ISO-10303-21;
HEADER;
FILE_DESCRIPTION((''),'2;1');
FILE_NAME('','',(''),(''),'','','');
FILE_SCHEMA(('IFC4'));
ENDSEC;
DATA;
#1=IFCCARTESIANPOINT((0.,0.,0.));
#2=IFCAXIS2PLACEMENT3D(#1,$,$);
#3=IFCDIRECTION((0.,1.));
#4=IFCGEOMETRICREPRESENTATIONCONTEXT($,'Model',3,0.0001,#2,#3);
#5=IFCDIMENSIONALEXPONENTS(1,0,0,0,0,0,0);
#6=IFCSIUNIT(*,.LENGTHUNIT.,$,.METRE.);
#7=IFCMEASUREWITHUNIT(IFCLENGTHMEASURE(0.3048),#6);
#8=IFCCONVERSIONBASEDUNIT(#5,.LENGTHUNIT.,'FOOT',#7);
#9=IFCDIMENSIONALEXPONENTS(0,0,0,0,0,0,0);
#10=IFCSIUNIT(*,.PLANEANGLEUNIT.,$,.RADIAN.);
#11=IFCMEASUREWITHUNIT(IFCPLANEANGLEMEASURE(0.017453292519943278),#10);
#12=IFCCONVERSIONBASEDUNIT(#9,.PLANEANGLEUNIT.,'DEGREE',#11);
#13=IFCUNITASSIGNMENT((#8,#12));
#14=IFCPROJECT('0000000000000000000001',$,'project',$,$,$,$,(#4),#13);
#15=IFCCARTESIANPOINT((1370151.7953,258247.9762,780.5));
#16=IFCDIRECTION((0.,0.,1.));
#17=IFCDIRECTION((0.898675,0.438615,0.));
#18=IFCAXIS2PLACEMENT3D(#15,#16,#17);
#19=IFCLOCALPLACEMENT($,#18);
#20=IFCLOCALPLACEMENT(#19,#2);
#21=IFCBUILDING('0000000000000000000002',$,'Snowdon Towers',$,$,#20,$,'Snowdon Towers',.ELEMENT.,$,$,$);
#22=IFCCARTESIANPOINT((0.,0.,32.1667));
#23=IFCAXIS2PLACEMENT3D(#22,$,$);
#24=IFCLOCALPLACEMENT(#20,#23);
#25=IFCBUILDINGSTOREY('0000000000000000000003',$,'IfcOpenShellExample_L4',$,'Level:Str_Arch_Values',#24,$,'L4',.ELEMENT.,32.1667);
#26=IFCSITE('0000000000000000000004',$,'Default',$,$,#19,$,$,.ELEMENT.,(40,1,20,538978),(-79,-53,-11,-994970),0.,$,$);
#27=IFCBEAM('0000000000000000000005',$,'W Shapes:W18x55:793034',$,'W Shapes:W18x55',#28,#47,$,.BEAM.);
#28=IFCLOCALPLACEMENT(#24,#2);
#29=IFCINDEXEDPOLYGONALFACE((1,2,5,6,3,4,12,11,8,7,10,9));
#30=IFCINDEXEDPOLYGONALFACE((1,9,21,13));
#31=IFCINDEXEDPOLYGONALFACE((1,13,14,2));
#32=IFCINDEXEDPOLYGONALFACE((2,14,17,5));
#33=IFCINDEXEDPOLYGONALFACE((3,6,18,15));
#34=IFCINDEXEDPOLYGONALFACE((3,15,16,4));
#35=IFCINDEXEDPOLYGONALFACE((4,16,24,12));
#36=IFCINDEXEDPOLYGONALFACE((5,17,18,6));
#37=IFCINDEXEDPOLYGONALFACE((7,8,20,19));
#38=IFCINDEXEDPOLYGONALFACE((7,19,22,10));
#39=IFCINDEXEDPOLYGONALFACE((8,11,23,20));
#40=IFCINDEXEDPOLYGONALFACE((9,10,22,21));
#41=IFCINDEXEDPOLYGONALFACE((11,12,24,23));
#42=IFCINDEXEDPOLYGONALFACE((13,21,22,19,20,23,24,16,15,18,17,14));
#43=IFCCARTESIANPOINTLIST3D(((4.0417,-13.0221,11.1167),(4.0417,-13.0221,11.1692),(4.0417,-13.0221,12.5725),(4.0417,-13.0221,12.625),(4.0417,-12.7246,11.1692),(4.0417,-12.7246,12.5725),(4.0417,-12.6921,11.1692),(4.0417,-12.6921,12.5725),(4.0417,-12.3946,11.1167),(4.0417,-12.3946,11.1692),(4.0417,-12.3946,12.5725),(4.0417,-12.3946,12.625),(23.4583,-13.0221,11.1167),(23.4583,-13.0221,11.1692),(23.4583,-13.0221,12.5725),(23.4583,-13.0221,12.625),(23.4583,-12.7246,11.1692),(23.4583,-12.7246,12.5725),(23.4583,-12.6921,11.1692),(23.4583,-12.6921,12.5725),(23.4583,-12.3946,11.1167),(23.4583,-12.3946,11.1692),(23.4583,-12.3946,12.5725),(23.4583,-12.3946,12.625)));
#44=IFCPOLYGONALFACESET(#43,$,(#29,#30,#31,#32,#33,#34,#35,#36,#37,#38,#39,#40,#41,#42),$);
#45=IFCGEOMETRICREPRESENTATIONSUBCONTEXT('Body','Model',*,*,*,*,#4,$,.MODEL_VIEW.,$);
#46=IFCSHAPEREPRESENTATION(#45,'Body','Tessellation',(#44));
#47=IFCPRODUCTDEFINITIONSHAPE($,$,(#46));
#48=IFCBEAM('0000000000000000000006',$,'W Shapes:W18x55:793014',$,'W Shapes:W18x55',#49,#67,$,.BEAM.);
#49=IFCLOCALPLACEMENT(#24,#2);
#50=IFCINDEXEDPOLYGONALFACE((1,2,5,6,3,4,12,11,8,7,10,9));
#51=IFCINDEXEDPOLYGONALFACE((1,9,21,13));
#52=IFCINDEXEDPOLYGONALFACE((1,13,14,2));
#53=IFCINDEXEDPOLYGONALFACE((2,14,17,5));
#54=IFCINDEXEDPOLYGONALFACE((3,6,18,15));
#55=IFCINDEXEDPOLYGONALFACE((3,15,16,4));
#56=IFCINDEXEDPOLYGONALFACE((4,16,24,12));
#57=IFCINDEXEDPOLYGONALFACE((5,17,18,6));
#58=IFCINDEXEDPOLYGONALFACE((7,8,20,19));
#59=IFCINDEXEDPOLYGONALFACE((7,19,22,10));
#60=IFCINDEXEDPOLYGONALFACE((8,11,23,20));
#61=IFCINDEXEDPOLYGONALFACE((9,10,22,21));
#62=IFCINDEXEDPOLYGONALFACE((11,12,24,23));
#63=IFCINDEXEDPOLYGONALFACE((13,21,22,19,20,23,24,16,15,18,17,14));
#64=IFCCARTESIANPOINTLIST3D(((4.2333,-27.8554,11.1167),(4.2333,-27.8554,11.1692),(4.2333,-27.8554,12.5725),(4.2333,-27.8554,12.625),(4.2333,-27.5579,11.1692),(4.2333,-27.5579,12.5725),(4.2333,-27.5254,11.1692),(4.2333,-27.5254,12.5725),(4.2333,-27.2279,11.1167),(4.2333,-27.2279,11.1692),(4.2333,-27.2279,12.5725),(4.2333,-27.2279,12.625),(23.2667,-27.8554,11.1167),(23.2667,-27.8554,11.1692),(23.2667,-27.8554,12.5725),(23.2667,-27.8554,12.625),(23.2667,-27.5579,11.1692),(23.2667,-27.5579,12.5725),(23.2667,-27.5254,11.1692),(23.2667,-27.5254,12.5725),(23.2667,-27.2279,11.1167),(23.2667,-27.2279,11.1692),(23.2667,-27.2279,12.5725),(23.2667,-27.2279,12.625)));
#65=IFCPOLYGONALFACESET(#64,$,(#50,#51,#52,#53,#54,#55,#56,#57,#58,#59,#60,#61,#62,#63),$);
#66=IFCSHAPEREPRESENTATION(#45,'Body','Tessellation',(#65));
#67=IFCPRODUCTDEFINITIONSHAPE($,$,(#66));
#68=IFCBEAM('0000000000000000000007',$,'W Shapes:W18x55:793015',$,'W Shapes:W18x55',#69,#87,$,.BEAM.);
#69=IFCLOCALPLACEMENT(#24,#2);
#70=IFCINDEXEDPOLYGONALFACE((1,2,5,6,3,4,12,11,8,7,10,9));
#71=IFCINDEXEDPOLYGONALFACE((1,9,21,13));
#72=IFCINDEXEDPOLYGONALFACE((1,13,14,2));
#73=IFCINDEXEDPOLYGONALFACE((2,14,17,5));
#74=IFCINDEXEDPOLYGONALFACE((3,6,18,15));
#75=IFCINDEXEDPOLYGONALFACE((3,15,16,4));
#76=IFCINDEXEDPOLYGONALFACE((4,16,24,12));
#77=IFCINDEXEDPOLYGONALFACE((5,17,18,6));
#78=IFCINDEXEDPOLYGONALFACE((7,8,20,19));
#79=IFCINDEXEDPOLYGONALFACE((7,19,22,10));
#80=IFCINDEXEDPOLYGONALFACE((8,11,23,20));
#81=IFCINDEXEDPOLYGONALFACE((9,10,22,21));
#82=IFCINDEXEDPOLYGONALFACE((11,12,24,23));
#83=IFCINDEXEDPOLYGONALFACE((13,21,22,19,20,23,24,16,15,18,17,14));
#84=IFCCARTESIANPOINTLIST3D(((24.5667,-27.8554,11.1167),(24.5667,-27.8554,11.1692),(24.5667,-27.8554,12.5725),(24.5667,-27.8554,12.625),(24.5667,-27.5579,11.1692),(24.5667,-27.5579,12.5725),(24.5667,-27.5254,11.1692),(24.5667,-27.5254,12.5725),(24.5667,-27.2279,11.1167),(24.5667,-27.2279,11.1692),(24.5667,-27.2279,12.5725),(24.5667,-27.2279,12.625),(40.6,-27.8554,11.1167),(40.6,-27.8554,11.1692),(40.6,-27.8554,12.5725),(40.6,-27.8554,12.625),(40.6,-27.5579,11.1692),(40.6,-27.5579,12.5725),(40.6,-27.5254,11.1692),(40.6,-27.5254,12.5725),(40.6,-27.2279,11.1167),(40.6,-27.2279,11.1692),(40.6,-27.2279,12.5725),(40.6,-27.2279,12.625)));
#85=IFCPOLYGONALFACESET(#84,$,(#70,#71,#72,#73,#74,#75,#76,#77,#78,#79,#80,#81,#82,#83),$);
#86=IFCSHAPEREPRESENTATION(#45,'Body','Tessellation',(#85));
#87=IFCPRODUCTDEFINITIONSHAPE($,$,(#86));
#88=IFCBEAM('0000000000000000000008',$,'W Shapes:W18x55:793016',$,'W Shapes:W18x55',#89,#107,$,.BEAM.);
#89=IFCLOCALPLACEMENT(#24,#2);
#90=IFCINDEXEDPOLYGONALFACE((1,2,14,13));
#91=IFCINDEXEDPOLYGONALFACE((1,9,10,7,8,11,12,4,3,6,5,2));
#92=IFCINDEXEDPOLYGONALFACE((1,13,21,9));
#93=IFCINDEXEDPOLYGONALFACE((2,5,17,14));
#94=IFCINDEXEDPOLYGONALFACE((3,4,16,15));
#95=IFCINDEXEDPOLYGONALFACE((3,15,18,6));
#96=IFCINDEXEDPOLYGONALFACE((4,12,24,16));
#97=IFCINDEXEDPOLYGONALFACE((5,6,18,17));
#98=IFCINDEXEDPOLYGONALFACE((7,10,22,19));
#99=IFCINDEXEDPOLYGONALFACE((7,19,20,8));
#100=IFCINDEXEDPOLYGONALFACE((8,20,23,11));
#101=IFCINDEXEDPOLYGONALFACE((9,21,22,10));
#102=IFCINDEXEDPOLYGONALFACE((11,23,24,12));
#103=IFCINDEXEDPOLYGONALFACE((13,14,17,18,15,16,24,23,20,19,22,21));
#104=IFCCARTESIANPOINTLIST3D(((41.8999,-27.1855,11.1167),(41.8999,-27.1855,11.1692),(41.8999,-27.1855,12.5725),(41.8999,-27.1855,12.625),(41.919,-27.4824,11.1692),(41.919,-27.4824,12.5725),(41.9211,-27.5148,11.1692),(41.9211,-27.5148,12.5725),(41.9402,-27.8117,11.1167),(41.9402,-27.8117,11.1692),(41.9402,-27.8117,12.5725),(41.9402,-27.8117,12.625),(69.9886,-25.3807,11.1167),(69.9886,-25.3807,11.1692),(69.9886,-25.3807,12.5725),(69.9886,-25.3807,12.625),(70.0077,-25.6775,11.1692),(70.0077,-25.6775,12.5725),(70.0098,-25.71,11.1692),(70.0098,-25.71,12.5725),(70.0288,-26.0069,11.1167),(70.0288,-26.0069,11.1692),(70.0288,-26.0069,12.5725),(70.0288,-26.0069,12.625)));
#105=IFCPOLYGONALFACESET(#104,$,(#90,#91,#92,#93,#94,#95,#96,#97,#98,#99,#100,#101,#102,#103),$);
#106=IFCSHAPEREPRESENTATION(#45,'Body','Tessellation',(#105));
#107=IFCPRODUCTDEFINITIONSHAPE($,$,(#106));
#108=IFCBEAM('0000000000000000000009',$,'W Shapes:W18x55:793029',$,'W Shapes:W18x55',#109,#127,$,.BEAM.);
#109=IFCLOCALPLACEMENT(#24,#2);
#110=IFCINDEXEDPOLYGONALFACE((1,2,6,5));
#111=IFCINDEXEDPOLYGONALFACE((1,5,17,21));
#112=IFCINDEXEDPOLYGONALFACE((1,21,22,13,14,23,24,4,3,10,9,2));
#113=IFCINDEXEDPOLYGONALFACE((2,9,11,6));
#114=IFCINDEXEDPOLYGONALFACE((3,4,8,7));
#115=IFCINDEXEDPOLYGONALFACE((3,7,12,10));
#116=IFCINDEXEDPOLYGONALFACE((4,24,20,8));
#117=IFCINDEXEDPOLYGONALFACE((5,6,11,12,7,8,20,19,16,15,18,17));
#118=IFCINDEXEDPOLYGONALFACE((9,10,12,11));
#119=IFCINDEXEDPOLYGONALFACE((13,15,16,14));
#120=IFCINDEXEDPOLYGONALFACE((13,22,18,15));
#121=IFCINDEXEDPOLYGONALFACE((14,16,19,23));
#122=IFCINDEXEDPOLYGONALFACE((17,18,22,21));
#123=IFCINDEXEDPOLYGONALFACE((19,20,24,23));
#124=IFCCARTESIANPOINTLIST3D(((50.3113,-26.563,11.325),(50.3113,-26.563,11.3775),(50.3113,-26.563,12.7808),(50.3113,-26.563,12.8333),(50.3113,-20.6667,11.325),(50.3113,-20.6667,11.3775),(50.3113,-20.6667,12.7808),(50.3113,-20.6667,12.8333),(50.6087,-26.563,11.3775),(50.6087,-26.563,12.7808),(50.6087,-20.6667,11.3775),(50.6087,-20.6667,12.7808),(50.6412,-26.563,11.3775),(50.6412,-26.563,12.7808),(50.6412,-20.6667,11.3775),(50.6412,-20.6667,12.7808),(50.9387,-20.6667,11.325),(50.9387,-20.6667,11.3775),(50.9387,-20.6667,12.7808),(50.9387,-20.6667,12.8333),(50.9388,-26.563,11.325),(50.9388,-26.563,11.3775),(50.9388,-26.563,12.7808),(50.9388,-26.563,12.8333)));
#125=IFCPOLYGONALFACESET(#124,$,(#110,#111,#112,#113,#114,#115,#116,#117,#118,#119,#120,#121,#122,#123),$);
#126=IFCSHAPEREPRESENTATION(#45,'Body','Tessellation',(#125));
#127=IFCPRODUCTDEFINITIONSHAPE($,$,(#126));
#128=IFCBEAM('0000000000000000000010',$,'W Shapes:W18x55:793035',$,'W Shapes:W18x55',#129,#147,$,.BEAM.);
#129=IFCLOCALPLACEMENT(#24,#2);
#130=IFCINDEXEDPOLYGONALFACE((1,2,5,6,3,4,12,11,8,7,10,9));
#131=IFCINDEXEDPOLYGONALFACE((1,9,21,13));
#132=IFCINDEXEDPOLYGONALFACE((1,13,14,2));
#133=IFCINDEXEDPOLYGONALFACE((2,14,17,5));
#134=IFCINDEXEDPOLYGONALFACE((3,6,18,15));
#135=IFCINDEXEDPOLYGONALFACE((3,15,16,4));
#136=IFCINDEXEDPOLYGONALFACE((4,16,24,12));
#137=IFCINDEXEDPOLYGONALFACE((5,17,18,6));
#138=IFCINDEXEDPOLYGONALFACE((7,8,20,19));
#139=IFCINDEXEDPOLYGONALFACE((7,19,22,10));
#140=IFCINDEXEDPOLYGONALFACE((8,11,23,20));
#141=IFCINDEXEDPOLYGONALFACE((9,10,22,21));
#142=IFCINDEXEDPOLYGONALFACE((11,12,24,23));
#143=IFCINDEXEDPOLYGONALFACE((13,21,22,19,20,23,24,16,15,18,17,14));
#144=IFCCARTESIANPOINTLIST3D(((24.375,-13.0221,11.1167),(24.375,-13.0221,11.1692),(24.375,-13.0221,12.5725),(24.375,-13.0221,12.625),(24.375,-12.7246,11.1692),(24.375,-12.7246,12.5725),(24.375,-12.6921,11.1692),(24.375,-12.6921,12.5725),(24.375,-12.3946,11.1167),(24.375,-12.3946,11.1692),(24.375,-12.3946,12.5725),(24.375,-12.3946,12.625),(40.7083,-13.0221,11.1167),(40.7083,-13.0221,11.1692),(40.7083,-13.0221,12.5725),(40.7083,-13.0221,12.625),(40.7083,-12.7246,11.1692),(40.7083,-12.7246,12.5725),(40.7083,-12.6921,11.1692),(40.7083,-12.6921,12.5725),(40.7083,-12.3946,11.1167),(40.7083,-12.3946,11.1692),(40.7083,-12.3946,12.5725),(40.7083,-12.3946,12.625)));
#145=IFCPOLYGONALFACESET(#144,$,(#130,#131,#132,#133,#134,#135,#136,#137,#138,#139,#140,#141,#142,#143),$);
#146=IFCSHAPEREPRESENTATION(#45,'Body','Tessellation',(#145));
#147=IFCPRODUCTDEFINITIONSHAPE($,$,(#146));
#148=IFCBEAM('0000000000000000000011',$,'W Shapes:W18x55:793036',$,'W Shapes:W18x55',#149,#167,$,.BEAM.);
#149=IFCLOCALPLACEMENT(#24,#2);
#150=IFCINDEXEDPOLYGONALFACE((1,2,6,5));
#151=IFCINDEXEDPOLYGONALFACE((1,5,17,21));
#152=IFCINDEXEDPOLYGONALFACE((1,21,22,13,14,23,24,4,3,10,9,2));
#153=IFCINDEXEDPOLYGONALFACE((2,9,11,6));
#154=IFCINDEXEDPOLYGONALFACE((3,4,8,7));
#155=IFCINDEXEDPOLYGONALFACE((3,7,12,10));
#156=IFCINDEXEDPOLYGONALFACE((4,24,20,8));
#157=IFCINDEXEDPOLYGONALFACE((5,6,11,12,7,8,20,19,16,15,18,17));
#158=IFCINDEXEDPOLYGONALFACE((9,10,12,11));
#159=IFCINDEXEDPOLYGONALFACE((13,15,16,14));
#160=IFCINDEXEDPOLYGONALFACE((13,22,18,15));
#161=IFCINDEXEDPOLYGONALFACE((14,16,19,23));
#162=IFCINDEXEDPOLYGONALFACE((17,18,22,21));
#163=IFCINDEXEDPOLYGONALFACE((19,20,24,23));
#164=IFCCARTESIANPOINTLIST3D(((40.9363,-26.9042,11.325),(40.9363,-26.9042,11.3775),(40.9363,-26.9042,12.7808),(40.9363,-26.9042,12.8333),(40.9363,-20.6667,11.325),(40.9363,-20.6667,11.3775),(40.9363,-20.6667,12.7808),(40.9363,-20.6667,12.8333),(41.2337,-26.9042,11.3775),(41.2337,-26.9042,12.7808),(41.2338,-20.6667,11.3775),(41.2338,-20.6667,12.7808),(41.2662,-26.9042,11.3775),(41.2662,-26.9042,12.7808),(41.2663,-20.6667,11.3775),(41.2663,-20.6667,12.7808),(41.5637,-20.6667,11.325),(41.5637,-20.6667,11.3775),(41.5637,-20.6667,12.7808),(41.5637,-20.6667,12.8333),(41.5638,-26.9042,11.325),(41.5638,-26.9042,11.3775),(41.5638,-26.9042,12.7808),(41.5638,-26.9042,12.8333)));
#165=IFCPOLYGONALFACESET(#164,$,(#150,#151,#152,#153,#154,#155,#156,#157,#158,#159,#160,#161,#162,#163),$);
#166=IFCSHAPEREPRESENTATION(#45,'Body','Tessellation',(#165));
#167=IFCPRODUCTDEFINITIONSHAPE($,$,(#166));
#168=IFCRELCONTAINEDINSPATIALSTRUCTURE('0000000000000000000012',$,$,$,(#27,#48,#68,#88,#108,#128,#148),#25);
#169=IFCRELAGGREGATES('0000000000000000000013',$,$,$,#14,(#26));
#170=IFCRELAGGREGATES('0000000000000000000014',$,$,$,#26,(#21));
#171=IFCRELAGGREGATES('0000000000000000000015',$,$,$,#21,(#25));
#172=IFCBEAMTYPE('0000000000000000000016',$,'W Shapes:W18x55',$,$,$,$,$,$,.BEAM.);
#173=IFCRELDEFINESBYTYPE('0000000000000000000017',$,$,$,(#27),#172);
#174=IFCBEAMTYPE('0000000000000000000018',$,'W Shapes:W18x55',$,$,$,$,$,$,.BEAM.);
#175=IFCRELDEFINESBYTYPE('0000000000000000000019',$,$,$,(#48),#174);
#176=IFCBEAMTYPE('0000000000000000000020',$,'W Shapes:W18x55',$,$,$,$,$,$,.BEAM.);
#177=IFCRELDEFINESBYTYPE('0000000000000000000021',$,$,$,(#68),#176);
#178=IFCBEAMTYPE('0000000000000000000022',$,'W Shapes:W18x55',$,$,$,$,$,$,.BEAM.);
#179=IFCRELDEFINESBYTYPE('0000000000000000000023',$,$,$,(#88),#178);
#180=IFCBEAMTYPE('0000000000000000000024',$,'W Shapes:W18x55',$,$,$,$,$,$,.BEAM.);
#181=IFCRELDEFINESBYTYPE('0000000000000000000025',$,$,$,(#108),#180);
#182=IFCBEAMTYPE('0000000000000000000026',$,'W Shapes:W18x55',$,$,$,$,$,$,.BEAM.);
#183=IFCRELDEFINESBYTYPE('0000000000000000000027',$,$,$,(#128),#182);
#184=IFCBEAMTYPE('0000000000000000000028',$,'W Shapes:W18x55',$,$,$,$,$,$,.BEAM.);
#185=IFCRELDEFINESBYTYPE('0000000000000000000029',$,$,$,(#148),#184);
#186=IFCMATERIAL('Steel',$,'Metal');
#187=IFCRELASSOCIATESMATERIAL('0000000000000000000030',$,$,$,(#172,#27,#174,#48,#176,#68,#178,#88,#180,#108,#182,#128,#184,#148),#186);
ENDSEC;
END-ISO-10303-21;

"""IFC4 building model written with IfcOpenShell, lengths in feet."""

from ifc_helpers import new_model, entity, si_unit, converted_unit, direction, frame, origin, place, context, subcontext, project, spatial, indexed_curve, outline, extrude, source, transform, mapped, material, type_object, type_shapes, element, save


model = new_model("IFC4")

# Units and contexts
model_context = context("Model", 3, precision=0.0001, world=origin(), true_north=direction((0.0, 1.0)))
body_context = subcontext(model_context, "Body", "Model", "MODEL_VIEW")
ifc_project = project(units=[converted_unit("LENGTHUNIT", "FOOT", entity("IfcLengthMeasure", 0.3048), si_unit("LENGTHUNIT", "METRE"), dimensions=[1, 0, 0, 0, 0, 0, 0]), converted_unit("PLANEANGLEUNIT", "DEGREE", entity("IfcPlaneAngleMeasure", 0.017453292519943278), si_unit("PLANEANGLEUNIT", "RADIAN"), dimensions=[0, 0, 0, 0, 0, 0, 0])], contexts=[model_context])

# Site, building, storey
site_placement = place(None, frame((1370151.7953, 258247.9762, 780.5), z_axis=(0.0, 0.0, 1.0), x_axis=(0.898675, 0.438615, 0.0)))
site = spatial("IfcSite", under=ifc_project, at=site_placement, Name="Default", CompositionType="ELEMENT", RefLatitude=(40, 1, 20, 538978), RefLongitude=(-79, -53, -11, -994970), RefElevation=0.0)
building_placement = place(site_placement, origin())
building = spatial("IfcBuilding", under=site, at=building_placement, Name="Snowdon Towers", LongName="Snowdon Towers", CompositionType="ELEMENT")
storey_placement = place(building_placement, frame((0.0, 0.0, 32.1667)))
storey = spatial("IfcBuildingStorey", under=building, at=storey_placement, Name="IfcOpenShellExample_L4", ObjectType="Level:Str_Arch_Values", LongName="L4", CompositionType="ELEMENT", Elevation=32.1667)

# Beams
ifc_material = material(Name="Steel", Category="Metal")
beam_type_1 = type_object("IfcBeamType", Name="W Shapes:W18x55", PredefinedType="BEAM", material=ifc_material)
shared_shape_1 = source(origin(), body_context, "Body", "SweptSolid", [
    extrude(outline(indexed_curve([(-0.3138, -0.7017), (-0.3138, -0.7542), (0.3138, -0.7542), (0.3138, -0.7017), (0.0162, -0.7017), (0.0162, 0.7017), (0.3138, 0.7017), (0.3138, 0.7542), (-0.3137, 0.7542), (-0.3137, 0.7017), (-0.0163, 0.7017), (-0.0163, -0.7017), (-0.3138, -0.7017)], self_intersect=False)), frame((-9.7917, 0.0, 0.0), z_axis=(-1.0, 0.0, 0.0), x_axis=(0.0, -1.0, 0.0)), (0.0, 0.0, -1.0), 19.4167),
])
type_shapes(beam_type_1, [shared_shape_1])
beam_1_placement = place(storey_placement, frame((13.8333, -12.7083, 11.8708)))
element("IfcBeam", 1, at=beam_1_placement, inside=storey, type_object=beam_type_1, material=ifc_material, Name="W Shapes:W18x55:793034", ObjectType="W Shapes:W18x55", PredefinedType="BEAM", context=body_context, shape_type="MappedRepresentation", body=[
    mapped(shared_shape_1, transform((0.0, 0.0, 0.0), scale=1.0)),
])
beam_type_2 = type_object("IfcBeamType", Name="W Shapes:W18x55", PredefinedType="BEAM", material=ifc_material)
shared_shape_2 = source(origin(), body_context, "Body", "SweptSolid", [
    extrude(outline(indexed_curve([(-0.3138, -0.7017), (-0.3138, -0.7542), (0.3138, -0.7542), (0.3138, -0.7017), (0.0162, -0.7017), (0.0162, 0.7017), (0.3138, 0.7017), (0.3138, 0.7542), (-0.3137, 0.7542), (-0.3137, 0.7017), (-0.0163, 0.7017), (-0.0163, -0.7017), (-0.3138, -0.7017)], self_intersect=False)), frame((-9.6, 0.0, 0.0), z_axis=(-1.0, 0.0, 0.0), x_axis=(0.0, -1.0, 0.0)), (0.0, 0.0, -1.0), 19.0333),
])
type_shapes(beam_type_2, [shared_shape_2])
beam_2_placement = place(storey_placement, frame((13.8333, -27.5417, 11.8708)))
element("IfcBeam", 2, at=beam_2_placement, inside=storey, type_object=beam_type_2, material=ifc_material, Name="W Shapes:W18x55:793014", ObjectType="W Shapes:W18x55", PredefinedType="BEAM", context=body_context, shape_type="MappedRepresentation", body=[
    mapped(shared_shape_2, transform((0.0, 0.0, 0.0), scale=1.0)),
])
beam_type_3 = type_object("IfcBeamType", Name="W Shapes:W18x55", PredefinedType="BEAM", material=ifc_material)
shared_shape_3 = source(origin(), body_context, "Body", "SweptSolid", [
    extrude(outline(indexed_curve([(-0.3138, -0.7017), (-0.3138, -0.7542), (0.3138, -0.7542), (0.3138, -0.7017), (0.0162, -0.7017), (0.0162, 0.7017), (0.3138, 0.7017), (0.3138, 0.7542), (-0.3137, 0.7542), (-0.3137, 0.7017), (-0.0163, 0.7017), (-0.0163, -0.7017), (-0.3138, -0.7017)], self_intersect=False)), frame((-8.0167, 0.0, 0.0), z_axis=(-1.0, 0.0, 0.0), x_axis=(0.0, -1.0, 0.0)), (0.0, 0.0, -1.0), 16.0333),
])
type_shapes(beam_type_3, [shared_shape_3])
beam_3_placement = place(storey_placement, frame((32.5833, -27.5417, 11.8708)))
element("IfcBeam", 3, at=beam_3_placement, inside=storey, type_object=beam_type_3, material=ifc_material, Name="W Shapes:W18x55:793015", ObjectType="W Shapes:W18x55", PredefinedType="BEAM", context=body_context, shape_type="MappedRepresentation", body=[
    mapped(shared_shape_3, transform((0.0, 0.0, 0.0), scale=1.0)),
])
beam_type_4 = type_object("IfcBeamType", Name="W Shapes:W18x55", PredefinedType="BEAM", material=ifc_material)
shared_shape_4 = source(origin(), body_context, "Body", "SweptSolid", [
    extrude(outline(indexed_curve([(-0.3138, -0.7017), (-0.3138, -0.7542), (0.3138, -0.7542), (0.3138, -0.7017), (0.0162, -0.7017), (0.0162, 0.7017), (0.3138, 0.7017), (0.3138, 0.7542), (-0.3137, 0.7542), (-0.3137, 0.7017), (-0.0163, 0.7017), (-0.0163, -0.7017), (-0.3138, -0.7017)], self_intersect=False)), frame((-14.3614, 0.0, 0.0), z_axis=(-1.0, 0.0, 0.0), x_axis=(0.0, -1.0, 0.0)), (0.0, 0.0, -1.0), 28.1466),
])
type_shapes(beam_type_4, [shared_shape_4])
beam_4_placement = place(storey_placement, frame((56.2518, -26.5777, 11.8708), z_axis=(0.0, 0.0, 1.0), x_axis=(0.997942, 0.064123, 0.0)))
element("IfcBeam", 4, at=beam_4_placement, inside=storey, type_object=beam_type_4, material=ifc_material, Name="W Shapes:W18x55:793016", ObjectType="W Shapes:W18x55", PredefinedType="BEAM", context=body_context, shape_type="MappedRepresentation", body=[
    mapped(shared_shape_4, transform((0.0, 0.0, 0.0), scale=1.0)),
])
beam_type_5 = type_object("IfcBeamType", Name="W Shapes:W18x55", PredefinedType="BEAM", material=ifc_material)
shared_shape_5 = source(origin(), body_context, "Body", "SweptSolid", [
    extrude(outline(indexed_curve([(-0.3138, -0.7017), (-0.3138, -0.7542), (0.3138, -0.7542), (0.3138, -0.7017), (0.0162, -0.7017), (0.0162, 0.7017), (0.3138, 0.7017), (0.3138, 0.7542), (-0.3137, 0.7542), (-0.3137, 0.7017), (-0.0163, 0.7017), (-0.0163, -0.7017), (-0.3138, -0.7017)], self_intersect=False)), frame((-2.8655, 0.0, 0.0), z_axis=(-1.0, 0.0, 0.0), x_axis=(0.0, -1.0, 0.0)), (0.0, 0.0, -1.0), 5.8964),
])
type_shapes(beam_type_5, [shared_shape_5])
beam_5_placement = place(storey_placement, frame((50.625, -23.5321, 12.0792), z_axis=(0.0, 0.0, 1.0), x_axis=(0.0, -1.0, 0.0)))
element("IfcBeam", 5, at=beam_5_placement, inside=storey, type_object=beam_type_5, material=ifc_material, Name="W Shapes:W18x55:793029", ObjectType="W Shapes:W18x55", PredefinedType="BEAM", context=body_context, shape_type="MappedRepresentation", body=[
    mapped(shared_shape_5, transform((0.0, 0.0, 0.0), scale=1.0)),
])
beam_type_6 = type_object("IfcBeamType", Name="W Shapes:W18x55", PredefinedType="BEAM", material=ifc_material)
shared_shape_6 = source(origin(), body_context, "Body", "SweptSolid", [
    extrude(outline(indexed_curve([(-0.3138, -0.7017), (-0.3138, -0.7542), (0.3138, -0.7542), (0.3138, -0.7017), (0.0162, -0.7017), (0.0162, 0.7017), (0.3138, 0.7017), (0.3138, 0.7542), (-0.3137, 0.7542), (-0.3137, 0.7017), (-0.0163, 0.7017), (-0.0163, -0.7017), (-0.3138, -0.7017)], self_intersect=False)), frame((-8.2083, 0.0, 0.0), z_axis=(-1.0, 0.0, 0.0), x_axis=(0.0, -1.0, 0.0)), (0.0, 0.0, -1.0), 16.3333),
])
type_shapes(beam_type_6, [shared_shape_6])
beam_6_placement = place(storey_placement, frame((32.5833, -12.7083, 11.8708)))
element("IfcBeam", 6, at=beam_6_placement, inside=storey, type_object=beam_type_6, material=ifc_material, Name="W Shapes:W18x55:793035", ObjectType="W Shapes:W18x55", PredefinedType="BEAM", context=body_context, shape_type="MappedRepresentation", body=[
    mapped(shared_shape_6, transform((0.0, 0.0, 0.0), scale=1.0)),
])
beam_type_7 = type_object("IfcBeamType", Name="W Shapes:W18x55", PredefinedType="BEAM", material=ifc_material)
shared_shape_7 = source(origin(), body_context, "Body", "SweptSolid", [
    extrude(outline(indexed_curve([(-0.3138, -0.7017), (-0.3138, -0.7542), (0.3138, -0.7542), (0.3138, -0.7017), (0.0162, -0.7017), (0.0162, 0.7017), (0.3138, 0.7017), (0.3138, 0.7542), (-0.3137, 0.7542), (-0.3137, 0.7017), (-0.0163, 0.7017), (-0.0163, -0.7017), (-0.3138, -0.7017)], self_intersect=False)), frame((-3.3958, 0.0, 0.0), z_axis=(-1.0, 0.0, 0.0), x_axis=(0.0, -1.0, 0.0)), (0.0, 0.0, -1.0), 6.2375),
])
type_shapes(beam_type_7, [shared_shape_7])
beam_7_placement = place(storey_placement, frame((41.25, -24.0625, 12.0792), z_axis=(0.0, 0.0, 1.0), x_axis=(0.0, -1.0, 0.0)))
element("IfcBeam", 7, at=beam_7_placement, inside=storey, type_object=beam_type_7, material=ifc_material, Name="W Shapes:W18x55:793036", ObjectType="W Shapes:W18x55", PredefinedType="BEAM", context=body_context, shape_type="MappedRepresentation", body=[
    mapped(shared_shape_7, transform((0.0, 0.0, 0.0), scale=1.0)),
])

save(model, "model.ifc")
